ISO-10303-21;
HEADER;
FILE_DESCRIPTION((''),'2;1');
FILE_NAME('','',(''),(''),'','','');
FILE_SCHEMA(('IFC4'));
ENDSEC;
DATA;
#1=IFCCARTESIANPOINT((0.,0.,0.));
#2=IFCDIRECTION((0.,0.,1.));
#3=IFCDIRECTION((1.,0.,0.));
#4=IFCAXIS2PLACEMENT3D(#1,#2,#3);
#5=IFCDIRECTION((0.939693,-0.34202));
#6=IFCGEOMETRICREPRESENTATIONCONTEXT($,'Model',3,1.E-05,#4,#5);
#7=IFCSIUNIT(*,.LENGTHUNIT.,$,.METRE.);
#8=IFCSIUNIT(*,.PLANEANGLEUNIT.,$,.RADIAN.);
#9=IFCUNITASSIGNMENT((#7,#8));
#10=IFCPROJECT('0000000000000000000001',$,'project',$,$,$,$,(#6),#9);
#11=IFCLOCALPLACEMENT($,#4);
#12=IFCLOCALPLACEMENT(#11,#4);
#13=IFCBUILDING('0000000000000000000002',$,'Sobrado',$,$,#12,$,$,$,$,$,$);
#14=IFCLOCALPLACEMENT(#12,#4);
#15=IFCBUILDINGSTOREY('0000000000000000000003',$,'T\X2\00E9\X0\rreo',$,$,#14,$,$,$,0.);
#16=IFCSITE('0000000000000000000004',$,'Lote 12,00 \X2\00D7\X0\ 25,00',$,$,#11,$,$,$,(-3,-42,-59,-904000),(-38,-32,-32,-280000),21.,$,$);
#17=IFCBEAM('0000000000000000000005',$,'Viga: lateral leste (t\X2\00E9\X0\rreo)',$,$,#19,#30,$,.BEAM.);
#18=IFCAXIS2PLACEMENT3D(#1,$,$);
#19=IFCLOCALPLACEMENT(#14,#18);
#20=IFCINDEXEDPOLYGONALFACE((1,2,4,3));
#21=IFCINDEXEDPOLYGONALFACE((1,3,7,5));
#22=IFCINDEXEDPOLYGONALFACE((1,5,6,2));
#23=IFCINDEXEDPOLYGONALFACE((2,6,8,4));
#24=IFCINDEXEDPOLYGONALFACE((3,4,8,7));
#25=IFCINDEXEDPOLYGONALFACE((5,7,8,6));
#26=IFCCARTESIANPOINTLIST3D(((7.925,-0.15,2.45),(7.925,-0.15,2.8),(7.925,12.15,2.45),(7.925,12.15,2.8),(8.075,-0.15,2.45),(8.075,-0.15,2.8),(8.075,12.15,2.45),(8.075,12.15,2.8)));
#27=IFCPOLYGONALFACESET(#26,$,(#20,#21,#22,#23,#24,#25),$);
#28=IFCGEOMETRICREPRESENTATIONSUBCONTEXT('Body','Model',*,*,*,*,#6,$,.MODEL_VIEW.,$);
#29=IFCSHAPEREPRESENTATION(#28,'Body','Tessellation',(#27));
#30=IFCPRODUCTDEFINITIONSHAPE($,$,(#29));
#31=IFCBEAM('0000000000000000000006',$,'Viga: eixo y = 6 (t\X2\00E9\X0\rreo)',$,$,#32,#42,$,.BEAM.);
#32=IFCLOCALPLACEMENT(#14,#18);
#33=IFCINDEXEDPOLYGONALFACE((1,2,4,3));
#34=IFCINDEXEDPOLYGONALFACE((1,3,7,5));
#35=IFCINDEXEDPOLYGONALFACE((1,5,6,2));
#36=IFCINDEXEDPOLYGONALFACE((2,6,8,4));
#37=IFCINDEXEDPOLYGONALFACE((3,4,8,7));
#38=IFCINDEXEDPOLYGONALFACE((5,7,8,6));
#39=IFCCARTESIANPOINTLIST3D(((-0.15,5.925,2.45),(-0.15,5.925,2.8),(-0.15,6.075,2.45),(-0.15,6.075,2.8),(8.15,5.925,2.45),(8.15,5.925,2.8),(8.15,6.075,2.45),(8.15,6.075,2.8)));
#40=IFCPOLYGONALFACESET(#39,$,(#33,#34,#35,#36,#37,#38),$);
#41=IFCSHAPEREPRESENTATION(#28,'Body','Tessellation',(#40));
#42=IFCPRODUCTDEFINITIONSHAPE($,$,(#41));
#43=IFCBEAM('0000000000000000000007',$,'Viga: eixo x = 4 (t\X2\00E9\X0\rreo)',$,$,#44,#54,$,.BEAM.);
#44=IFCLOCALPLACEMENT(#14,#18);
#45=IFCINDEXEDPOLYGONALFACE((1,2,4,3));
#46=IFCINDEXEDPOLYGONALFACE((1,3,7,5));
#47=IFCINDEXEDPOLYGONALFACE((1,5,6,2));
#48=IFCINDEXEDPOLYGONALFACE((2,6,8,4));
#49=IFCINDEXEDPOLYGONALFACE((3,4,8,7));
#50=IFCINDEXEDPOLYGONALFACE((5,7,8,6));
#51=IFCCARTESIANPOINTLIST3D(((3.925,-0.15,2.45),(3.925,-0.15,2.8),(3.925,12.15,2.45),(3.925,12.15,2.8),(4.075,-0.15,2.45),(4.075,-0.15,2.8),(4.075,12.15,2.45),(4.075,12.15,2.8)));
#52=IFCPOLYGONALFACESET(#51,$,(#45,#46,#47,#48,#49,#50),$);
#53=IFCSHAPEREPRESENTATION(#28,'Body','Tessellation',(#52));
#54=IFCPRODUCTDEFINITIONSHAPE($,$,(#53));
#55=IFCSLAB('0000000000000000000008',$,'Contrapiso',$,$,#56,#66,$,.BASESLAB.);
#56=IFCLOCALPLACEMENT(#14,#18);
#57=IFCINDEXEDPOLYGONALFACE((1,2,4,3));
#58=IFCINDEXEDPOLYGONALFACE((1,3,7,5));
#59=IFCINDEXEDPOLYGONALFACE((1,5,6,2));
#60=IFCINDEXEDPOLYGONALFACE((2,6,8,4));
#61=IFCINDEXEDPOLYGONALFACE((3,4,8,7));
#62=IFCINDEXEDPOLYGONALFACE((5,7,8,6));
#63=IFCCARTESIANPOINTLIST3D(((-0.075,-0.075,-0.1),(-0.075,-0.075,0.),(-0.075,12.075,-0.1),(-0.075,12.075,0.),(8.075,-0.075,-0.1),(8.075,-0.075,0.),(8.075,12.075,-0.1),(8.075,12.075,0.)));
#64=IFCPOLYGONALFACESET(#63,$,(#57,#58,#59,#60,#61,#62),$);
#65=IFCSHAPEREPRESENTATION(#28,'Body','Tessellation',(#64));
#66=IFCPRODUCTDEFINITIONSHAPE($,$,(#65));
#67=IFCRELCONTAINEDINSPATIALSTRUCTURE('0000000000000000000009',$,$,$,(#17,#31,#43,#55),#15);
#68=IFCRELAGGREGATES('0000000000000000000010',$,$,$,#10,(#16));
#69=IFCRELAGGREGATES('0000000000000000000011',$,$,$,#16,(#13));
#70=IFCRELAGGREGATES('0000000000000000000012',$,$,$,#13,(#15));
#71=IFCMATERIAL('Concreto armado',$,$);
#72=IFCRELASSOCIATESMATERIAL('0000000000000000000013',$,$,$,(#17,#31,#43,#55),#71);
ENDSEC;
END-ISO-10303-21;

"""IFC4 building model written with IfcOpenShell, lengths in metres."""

from ifc_helpers import new_model, si_unit, direction, frame, origin_with_axes, place, context, subcontext, project, spatial, line, indexed_curve, outline, extrude, material, element, save


model = new_model("IFC4")

# Units and contexts
model_context = context("Model", 3, precision=1e-05, world=origin_with_axes(), true_north=direction((0.939693, -0.34202)))
body_context = subcontext(model_context, "Body", "Model", "MODEL_VIEW")
ifc_project = project(units=[si_unit("LENGTHUNIT", "METRE"), si_unit("PLANEANGLEUNIT", "RADIAN")], contexts=[model_context])

# Site, building, storey
site_placement = place(None, origin_with_axes())
site = spatial("IfcSite", under=ifc_project, at=site_placement, Name="Lote 12,00 × 25,00", RefLatitude=(-3, -42, -59, -904000), RefLongitude=(-38, -32, -32, -280000), RefElevation=21.0)
building_placement = place(site_placement, origin_with_axes())
building = spatial("IfcBuilding", under=site, at=building_placement, Name="Sobrado")
storey_placement = place(building_placement, origin_with_axes())
storey = spatial("IfcBuildingStorey", under=building, at=storey_placement, Name="Térreo", Elevation=0.0)

# Shared definitions
ifc_material = material(Name="Concreto armado")

# Beams
beam_1_placement = place(storey_placement, origin_with_axes())
element("IfcBeam", 1, at=beam_1_placement, inside=storey, material=ifc_material, Name="Viga: lateral leste (térreo)", PredefinedType="BEAM", context=body_context, shape_type="SweptSolid", body=[
    extrude(outline(indexed_curve([(7.925, -0.15), (8.075, -0.15), (8.075, 12.15), (7.925, 12.15)], segments=[line(1, 2, 3, 4, 1)])), frame((0.0, 0.0, 2.45), z_axis=(0.0, 0.0, 1.0), x_axis=(1.0, 0.0, 0.0)), (0.0, 0.0, 1.0), 0.35),
])
beam_2_placement = place(storey_placement, origin_with_axes())
element("IfcBeam", 2, at=beam_2_placement, inside=storey, material=ifc_material, Name="Viga: eixo y = 6 (térreo)", PredefinedType="BEAM", context=body_context, shape_type="SweptSolid", body=[
    extrude(outline(indexed_curve([(-0.15, 5.925), (8.15, 5.925), (8.15, 6.075), (-0.15, 6.075)], segments=[line(1, 2, 3, 4, 1)])), frame((0.0, 0.0, 2.45), z_axis=(0.0, 0.0, 1.0), x_axis=(1.0, 0.0, 0.0)), (0.0, 0.0, 1.0), 0.35),
])
beam_3_placement = place(storey_placement, origin_with_axes())
element("IfcBeam", 3, at=beam_3_placement, inside=storey, material=ifc_material, Name="Viga: eixo x = 4 (térreo)", PredefinedType="BEAM", context=body_context, shape_type="SweptSolid", body=[
    extrude(outline(indexed_curve([(3.925, -0.15), (4.075, -0.15), (4.075, 12.15), (3.925, 12.15)], segments=[line(1, 2, 3, 4, 1)])), frame((0.0, 0.0, 2.45), z_axis=(0.0, 0.0, 1.0), x_axis=(1.0, 0.0, 0.0)), (0.0, 0.0, 1.0), 0.35),
])

# Slab
slab_placement = place(storey_placement, origin_with_axes())
element("IfcSlab", 4, at=slab_placement, inside=storey, material=ifc_material, Name="Contrapiso", PredefinedType="BASESLAB", context=body_context, shape_type="SweptSolid", body=[
    extrude(outline(indexed_curve([(-0.075, -0.075), (8.075, -0.075), (8.075, 12.075), (-0.075, 12.075)], segments=[line(1, 2, 3, 4, 1)])), frame((0.0, 0.0, -0.1), z_axis=(0.0, 0.0, 1.0), x_axis=(1.0, 0.0, 0.0)), (0.0, 0.0, 1.0), 0.1),
])

save(model, "model.ifc")
